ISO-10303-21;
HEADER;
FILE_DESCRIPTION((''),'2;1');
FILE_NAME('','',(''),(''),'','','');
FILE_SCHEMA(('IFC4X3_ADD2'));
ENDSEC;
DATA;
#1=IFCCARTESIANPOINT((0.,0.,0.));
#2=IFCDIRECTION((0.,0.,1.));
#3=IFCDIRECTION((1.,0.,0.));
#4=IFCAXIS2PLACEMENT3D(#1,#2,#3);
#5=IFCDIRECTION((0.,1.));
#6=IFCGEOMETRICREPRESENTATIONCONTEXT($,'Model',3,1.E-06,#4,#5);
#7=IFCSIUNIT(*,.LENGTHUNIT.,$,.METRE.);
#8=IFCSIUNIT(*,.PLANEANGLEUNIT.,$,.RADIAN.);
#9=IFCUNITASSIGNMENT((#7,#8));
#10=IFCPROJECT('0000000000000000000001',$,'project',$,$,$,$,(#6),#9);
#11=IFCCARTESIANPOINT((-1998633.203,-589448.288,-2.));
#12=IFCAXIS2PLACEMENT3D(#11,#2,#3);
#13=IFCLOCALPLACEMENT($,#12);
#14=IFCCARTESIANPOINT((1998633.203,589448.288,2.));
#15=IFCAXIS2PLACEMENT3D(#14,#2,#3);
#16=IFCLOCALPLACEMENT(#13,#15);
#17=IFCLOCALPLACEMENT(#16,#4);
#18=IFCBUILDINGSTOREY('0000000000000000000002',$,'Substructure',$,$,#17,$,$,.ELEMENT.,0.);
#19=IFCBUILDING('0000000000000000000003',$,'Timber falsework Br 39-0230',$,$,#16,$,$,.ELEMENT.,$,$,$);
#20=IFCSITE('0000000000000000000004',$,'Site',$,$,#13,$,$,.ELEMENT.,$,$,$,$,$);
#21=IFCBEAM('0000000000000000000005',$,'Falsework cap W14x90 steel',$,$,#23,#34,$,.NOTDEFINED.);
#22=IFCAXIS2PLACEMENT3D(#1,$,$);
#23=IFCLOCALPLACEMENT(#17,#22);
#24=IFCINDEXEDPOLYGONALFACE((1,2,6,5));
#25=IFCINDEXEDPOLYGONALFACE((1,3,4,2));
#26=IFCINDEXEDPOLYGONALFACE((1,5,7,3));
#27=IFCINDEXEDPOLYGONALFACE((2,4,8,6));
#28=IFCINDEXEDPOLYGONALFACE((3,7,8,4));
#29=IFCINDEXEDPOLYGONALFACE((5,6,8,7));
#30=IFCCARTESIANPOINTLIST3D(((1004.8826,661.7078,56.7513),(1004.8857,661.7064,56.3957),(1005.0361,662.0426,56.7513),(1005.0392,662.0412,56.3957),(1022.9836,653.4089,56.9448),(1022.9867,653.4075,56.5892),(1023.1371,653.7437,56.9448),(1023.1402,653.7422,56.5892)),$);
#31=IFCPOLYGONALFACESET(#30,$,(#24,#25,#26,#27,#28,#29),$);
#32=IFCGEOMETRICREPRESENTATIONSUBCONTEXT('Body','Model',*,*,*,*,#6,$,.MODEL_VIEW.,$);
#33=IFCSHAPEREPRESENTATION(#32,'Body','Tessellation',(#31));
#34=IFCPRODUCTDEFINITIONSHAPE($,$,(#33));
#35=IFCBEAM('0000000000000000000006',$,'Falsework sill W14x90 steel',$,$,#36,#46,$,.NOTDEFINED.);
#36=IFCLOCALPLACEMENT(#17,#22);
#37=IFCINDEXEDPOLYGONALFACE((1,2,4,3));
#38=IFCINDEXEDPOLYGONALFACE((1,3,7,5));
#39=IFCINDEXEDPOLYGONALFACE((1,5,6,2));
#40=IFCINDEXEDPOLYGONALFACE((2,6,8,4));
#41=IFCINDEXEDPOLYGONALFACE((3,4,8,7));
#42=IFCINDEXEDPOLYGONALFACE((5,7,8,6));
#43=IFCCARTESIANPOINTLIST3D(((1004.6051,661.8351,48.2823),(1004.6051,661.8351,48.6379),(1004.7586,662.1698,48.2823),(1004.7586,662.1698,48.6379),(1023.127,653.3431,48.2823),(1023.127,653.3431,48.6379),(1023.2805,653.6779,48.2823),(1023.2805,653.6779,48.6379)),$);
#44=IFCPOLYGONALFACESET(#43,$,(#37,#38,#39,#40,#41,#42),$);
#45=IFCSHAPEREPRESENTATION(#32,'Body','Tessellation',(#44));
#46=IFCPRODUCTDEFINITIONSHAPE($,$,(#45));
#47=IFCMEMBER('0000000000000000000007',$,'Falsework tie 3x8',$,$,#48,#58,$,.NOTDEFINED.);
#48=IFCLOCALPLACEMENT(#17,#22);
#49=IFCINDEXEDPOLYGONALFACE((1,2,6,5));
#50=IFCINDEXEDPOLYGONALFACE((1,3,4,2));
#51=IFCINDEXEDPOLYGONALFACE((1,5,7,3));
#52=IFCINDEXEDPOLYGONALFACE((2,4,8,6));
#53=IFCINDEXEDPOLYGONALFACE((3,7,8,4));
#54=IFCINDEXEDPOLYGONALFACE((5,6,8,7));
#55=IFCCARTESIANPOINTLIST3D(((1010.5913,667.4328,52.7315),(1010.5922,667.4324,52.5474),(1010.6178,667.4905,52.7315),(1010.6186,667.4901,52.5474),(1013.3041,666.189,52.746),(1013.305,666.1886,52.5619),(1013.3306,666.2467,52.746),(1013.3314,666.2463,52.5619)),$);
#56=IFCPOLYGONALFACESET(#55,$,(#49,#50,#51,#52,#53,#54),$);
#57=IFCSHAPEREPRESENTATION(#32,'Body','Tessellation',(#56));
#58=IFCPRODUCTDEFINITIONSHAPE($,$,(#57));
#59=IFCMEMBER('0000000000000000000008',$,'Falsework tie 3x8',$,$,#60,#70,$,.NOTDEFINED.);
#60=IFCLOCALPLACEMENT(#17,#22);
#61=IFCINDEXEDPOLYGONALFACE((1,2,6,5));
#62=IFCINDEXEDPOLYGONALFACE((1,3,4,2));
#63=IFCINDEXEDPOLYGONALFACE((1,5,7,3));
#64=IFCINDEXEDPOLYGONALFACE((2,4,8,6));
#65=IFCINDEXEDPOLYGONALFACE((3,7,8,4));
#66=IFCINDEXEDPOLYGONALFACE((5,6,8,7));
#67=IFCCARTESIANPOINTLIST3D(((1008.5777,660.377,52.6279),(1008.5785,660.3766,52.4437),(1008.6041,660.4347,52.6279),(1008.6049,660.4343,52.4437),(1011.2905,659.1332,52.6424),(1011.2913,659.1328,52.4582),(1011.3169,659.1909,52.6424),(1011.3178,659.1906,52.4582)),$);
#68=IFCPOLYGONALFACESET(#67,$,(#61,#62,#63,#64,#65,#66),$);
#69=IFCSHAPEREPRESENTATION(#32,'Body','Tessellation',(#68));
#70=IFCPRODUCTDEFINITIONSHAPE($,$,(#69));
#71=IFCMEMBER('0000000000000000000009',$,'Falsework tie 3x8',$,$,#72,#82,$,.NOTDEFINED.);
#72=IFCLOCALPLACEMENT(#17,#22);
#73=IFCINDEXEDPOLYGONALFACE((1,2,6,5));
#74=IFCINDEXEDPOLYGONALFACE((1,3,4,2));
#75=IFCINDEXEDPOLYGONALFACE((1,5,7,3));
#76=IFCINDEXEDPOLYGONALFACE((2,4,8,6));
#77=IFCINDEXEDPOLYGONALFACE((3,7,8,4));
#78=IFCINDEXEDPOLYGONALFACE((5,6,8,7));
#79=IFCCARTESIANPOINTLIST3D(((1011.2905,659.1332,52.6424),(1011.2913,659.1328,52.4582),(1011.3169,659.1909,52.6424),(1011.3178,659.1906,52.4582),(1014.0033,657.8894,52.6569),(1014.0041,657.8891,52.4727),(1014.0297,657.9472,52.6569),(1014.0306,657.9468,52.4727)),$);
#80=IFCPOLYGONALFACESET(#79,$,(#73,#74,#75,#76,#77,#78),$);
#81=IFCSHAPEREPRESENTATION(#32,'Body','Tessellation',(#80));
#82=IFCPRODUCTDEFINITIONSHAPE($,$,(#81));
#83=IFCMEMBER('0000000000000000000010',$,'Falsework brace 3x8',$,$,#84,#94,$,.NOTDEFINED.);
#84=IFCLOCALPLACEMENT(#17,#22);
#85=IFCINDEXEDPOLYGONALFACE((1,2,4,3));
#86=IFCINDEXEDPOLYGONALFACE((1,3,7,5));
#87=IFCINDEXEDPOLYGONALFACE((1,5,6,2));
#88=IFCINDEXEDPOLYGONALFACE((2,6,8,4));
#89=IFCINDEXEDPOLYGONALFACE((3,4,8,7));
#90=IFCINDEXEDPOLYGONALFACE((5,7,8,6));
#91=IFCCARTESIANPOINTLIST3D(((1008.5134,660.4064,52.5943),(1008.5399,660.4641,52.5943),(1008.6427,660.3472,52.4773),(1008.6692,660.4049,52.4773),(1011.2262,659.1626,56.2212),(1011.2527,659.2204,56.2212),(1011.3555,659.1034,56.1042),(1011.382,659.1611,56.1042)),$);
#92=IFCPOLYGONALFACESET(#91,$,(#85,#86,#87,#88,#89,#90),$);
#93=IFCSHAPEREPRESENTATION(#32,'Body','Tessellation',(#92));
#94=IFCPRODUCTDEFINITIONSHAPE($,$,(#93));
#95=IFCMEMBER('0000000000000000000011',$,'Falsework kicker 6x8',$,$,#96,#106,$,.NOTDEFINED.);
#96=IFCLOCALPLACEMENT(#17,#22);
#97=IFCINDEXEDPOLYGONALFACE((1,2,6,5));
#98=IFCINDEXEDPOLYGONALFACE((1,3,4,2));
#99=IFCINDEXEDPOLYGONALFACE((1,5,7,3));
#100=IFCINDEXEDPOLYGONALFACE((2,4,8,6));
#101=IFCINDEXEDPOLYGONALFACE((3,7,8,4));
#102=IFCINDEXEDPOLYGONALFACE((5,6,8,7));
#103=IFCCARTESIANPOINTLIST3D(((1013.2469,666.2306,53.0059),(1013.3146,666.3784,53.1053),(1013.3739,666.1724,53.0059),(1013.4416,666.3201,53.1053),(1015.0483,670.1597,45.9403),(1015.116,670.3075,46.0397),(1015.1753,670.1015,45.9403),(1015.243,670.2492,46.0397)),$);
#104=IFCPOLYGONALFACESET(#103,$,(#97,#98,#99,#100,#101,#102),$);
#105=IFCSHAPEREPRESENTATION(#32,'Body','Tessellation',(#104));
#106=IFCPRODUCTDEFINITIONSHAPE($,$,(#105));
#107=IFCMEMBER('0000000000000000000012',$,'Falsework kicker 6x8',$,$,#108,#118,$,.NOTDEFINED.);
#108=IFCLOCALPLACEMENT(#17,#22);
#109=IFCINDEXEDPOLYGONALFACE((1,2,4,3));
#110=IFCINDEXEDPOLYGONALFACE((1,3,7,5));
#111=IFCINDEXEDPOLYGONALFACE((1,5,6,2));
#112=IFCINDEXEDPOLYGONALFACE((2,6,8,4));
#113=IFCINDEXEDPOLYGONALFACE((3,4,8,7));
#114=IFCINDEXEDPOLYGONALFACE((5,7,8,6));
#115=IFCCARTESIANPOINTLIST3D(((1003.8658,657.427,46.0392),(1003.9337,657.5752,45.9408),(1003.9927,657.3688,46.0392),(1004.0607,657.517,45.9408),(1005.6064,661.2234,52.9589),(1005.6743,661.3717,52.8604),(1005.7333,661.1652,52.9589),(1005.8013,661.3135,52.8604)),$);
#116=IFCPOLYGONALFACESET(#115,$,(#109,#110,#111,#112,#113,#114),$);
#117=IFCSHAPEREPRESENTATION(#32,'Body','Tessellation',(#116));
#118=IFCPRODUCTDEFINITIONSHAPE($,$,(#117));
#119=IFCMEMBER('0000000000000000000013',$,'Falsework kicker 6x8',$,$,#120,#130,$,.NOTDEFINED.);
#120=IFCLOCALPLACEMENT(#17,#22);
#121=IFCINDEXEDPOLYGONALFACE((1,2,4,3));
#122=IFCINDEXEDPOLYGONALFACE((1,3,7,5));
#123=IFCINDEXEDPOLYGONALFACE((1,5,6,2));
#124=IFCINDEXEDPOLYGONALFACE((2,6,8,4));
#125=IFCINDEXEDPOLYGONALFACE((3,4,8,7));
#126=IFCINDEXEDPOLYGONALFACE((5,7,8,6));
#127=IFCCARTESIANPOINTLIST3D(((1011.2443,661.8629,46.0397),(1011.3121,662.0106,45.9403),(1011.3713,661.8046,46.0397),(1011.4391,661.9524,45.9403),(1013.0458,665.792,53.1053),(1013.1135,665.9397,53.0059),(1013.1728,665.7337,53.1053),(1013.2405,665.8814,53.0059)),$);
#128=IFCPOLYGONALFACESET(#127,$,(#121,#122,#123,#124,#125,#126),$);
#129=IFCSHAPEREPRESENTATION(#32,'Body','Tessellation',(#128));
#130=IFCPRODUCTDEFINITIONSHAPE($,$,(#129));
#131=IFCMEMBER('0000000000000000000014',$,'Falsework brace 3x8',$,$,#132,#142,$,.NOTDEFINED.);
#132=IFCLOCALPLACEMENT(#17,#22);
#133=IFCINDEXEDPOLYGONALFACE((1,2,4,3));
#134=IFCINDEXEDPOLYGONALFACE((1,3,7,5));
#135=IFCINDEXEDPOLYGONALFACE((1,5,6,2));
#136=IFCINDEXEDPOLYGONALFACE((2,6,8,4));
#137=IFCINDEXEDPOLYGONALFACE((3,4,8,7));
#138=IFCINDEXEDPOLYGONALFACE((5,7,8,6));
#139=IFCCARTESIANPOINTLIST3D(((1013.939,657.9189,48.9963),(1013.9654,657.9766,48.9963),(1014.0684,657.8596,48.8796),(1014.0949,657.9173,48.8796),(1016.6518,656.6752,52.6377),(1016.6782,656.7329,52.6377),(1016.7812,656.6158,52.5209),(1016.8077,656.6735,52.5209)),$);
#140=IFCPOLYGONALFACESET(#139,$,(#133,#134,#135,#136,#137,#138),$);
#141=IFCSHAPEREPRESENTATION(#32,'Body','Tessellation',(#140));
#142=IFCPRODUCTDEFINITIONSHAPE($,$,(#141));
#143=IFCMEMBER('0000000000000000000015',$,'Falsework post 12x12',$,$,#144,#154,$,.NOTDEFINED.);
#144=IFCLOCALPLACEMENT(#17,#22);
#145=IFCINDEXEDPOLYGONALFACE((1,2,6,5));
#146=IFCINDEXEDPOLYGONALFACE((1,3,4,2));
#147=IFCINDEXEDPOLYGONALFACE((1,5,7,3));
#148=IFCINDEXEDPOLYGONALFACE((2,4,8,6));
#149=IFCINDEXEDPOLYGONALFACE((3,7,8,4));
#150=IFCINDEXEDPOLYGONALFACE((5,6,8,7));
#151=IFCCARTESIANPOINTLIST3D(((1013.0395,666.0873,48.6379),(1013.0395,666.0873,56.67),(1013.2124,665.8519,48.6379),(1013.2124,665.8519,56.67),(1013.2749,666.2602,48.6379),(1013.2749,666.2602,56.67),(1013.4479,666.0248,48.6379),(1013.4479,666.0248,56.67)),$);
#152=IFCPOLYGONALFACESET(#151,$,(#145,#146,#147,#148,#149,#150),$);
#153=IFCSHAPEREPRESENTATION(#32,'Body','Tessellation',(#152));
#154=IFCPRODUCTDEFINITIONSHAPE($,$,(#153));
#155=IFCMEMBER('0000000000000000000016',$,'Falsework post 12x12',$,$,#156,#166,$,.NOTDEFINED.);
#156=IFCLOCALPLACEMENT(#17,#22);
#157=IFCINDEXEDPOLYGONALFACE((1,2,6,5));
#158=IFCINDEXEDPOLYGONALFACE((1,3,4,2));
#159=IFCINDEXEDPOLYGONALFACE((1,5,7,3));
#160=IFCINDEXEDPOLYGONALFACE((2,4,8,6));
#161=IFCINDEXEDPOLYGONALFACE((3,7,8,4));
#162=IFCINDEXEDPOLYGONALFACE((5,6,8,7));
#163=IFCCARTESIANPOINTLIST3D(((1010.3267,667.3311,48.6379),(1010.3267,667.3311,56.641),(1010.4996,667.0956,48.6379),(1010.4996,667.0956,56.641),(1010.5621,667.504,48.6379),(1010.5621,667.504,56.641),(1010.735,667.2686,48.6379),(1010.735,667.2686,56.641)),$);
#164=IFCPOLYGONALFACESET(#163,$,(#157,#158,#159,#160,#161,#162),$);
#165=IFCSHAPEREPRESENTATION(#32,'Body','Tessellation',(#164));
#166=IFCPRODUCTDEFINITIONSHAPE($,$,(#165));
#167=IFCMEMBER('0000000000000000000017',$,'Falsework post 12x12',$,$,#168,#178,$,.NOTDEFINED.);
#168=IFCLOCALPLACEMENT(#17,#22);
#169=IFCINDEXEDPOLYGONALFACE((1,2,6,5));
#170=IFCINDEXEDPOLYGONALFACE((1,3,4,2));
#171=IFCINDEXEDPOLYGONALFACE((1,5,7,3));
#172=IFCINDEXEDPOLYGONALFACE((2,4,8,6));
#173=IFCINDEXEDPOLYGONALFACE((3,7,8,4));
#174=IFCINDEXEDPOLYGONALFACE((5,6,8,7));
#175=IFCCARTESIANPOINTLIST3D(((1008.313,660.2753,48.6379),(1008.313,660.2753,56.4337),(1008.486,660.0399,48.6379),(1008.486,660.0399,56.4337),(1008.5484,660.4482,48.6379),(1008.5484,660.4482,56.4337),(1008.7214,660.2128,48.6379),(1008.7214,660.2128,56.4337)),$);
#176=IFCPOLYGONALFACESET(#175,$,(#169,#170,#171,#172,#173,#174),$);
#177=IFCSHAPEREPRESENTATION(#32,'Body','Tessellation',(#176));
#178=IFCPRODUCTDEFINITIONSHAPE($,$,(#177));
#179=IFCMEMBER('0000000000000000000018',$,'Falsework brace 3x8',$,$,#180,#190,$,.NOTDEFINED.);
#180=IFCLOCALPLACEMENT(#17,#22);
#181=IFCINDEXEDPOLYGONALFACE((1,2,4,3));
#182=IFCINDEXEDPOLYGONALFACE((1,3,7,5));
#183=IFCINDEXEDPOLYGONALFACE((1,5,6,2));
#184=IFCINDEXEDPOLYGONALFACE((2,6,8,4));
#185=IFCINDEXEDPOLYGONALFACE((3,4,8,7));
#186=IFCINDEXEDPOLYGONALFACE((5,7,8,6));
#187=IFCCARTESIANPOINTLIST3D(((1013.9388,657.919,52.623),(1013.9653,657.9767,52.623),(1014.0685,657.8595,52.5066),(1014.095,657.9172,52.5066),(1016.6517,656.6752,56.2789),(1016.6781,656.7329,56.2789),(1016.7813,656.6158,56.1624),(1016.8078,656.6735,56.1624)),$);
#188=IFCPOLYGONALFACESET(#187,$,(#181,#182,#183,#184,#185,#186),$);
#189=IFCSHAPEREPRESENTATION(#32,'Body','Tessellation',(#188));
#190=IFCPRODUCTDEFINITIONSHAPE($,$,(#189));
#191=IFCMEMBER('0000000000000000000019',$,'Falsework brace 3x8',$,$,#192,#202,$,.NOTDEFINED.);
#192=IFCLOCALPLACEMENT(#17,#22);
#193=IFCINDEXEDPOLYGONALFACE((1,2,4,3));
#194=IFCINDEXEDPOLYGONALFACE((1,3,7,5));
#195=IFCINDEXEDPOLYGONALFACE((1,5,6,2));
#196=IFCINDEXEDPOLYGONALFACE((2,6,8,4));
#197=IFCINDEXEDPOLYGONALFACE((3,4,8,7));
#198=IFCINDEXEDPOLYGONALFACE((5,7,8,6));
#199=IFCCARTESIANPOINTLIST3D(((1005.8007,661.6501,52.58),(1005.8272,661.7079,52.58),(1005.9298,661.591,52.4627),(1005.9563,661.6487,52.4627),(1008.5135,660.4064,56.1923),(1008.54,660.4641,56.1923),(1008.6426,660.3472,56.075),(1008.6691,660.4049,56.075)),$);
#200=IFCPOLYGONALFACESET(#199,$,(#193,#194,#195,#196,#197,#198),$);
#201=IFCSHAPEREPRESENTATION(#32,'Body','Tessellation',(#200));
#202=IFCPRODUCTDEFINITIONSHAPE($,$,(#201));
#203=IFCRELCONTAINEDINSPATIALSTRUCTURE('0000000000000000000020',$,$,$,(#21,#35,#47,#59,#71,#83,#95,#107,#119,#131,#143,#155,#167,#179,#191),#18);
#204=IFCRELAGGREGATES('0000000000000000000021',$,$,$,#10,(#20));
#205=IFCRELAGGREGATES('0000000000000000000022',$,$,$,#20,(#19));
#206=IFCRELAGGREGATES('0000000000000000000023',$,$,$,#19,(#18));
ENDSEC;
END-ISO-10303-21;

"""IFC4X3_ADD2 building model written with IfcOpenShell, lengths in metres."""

from ifc_helpers import new_model, si_unit, direction, frame, frame_2d, origin, origin_with_axes, origin_2d, place, context, subcontext, project, spatial, rectangle, extrude, element, save


model = new_model("IFC4X3_ADD2")

# Units and contexts
model_context = context("Model", 3, precision=1e-06, world=origin_with_axes(), true_north=direction((0.0, 1.0)))
body_context = subcontext(model_context, "Body", "Model", "MODEL_VIEW")
ifc_project = project(units=[si_unit("LENGTHUNIT", "METRE"), si_unit("PLANEANGLEUNIT", "RADIAN")], contexts=[model_context])

# Site, building, storey
site_placement = place(None, frame((-1998633.203, -589448.288, -2.0), z_axis=(0.0, 0.0, 1.0), x_axis=(1.0, 0.0, 0.0)))
site = spatial("IfcSite", under=ifc_project, at=site_placement, Name="Site", CompositionType="ELEMENT")
building_placement = place(site_placement, frame((1998633.203, 589448.288, 2.0), z_axis=(0.0, 0.0, 1.0), x_axis=(1.0, 0.0, 0.0)))
building = spatial("IfcBuilding", under=site, at=building_placement, Name="Timber falsework Br 39-0230", CompositionType="ELEMENT")
storey_placement = place(building_placement, origin_with_axes())
storey = spatial("IfcBuildingStorey", under=building, at=storey_placement, Name="Substructure", CompositionType="ELEMENT", Elevation=0.0)

# Beams
beam_1_placement = place(storey_placement, frame((1004.9625, 661.8738, 56.3957), z_axis=(0.908971, -0.416746, 0.009717), x_axis=(0.416765, 0.909014, 0.0)))
element("IfcBeam", 1, at=beam_1_placement, inside=storey, Name="Falsework cap W14x90 steel", PredefinedType="NOTDEFINED", context=body_context, shape_type="SweptSolid", body=[
    extrude(rectangle(XDim=0.3683, YDim=0.3556, at=frame_2d((0.0, 0.1778))), origin(), (0.0, 0.0, 1.0), 19.9137),
])
beam_2_placement = place(storey_placement, frame((1004.6819, 662.0025, 48.2823), z_axis=(0.909014, -0.416765, 0.0), x_axis=(0.416765, 0.909014, 0.0)))
element("IfcBeam", 2, at=beam_2_placement, inside=storey, Name="Falsework sill W14x90 steel", PredefinedType="NOTDEFINED", context=body_context, shape_type="SweptSolid", body=[
    extrude(rectangle(XDim=0.3683, YDim=0.3556, at=frame_2d((0.0, 0.1778))), origin(), (0.0, 0.0, 1.0), 20.3758),
])

# Members
for number, where, z_axis, x_axis, name in (
    (3, (1010.605, 667.4614, 52.6395), (0.909003, -0.41676, 0.004859), (0.416765, 0.909014, 0.0), "Falsework tie 3x8"),
    (4, (1008.5913, 660.4056, 52.5358), (0.909003, -0.41676, 0.004859), (0.416765, 0.909014, 0.0), "Falsework tie 3x8"),
    (5, (1011.3041, 659.1619, 52.5503), (0.909003, -0.41676, 0.004859), (0.416765, 0.909014, 0.0), "Falsework tie 3x8"),
):
    element("IfcMember", number, at=place(storey_placement, frame(where, z_axis=z_axis, x_axis=x_axis)), inside=storey, Name=name, PredefinedType="NOTDEFINED", context=body_context, shape_type="SweptSolid", body=[
        extrude(rectangle(XDim=0.0635, YDim=0.1841, at=origin_2d()), origin(), (0.0, 0.0, 1.0), 2.9844),
    ])
member_1_placement = place(storey_placement, frame((1008.5913, 660.4056, 52.5358), z_axis=(0.57758, -0.264809, 0.77219), x_axis=(0.416765, 0.909014, 0.0)))
element("IfcMember", 6, at=member_1_placement, inside=storey, Name="Falsework brace 3x8", PredefinedType="NOTDEFINED", context=body_context, shape_type="SweptSolid", body=[
    extrude(rectangle(XDim=0.0635, YDim=0.1841, at=origin_2d()), origin(), (0.0, 0.0, 1.0), 4.6969),
])
member_2_placement = place(storey_placement, frame((1013.3443, 666.2754, 53.0556), z_axis=(0.217488, 0.474367, -0.853039), x_axis=(-0.909014, 0.416765, 0.0)))
element("IfcMember", 7, at=member_2_placement, inside=storey, Name="Falsework kicker 6x8", PredefinedType="NOTDEFINED", context=body_context, shape_type="SweptSolid", body=[
    extrude(rectangle(XDim=0.1397, YDim=0.1905, at=origin_2d()), origin(), (0.0, 0.0, 1.0), 8.2828),
])
member_3_placement = place(storey_placement, frame((1005.7038, 661.2684, 52.9096), z_axis=(-0.215358, -0.469722, -0.856144), x_axis=(0.909014, -0.416765, 0.0)))
element("IfcMember", 8, at=member_3_placement, inside=storey, Name="Falsework kicker 6x8", PredefinedType="NOTDEFINED", context=body_context, shape_type="SweptSolid", body=[
    extrude(rectangle(XDim=0.1397, YDim=0.1905, at=origin_2d()), origin(), (0.0, 0.0, 1.0), 8.0823),
])
member_4_placement = place(storey_placement, frame((1013.1431, 665.8367, 53.0556), z_axis=(-0.217488, -0.474367, -0.853039), x_axis=(0.909014, -0.416765, 0.0)))
element("IfcMember", 9, at=member_4_placement, inside=storey, Name="Falsework kicker 6x8", PredefinedType="NOTDEFINED", context=body_context, shape_type="SweptSolid", body=[
    extrude(rectangle(XDim=0.1397, YDim=0.1905, at=origin_2d()), origin(), (0.0, 0.0, 1.0), 8.2828),
])
member_5_placement = place(storey_placement, frame((1014.0169, 657.9181, 48.9379), z_axis=(0.576205, -0.264179, 0.773432), x_axis=(0.416765, 0.909014, 0.0)))
element("IfcMember", 10, at=member_5_placement, inside=storey, Name="Falsework brace 3x8", PredefinedType="NOTDEFINED", context=body_context, shape_type="SweptSolid", body=[
    extrude(rectangle(XDim=0.0635, YDim=0.1841, at=origin_2d()), origin(), (0.0, 0.0, 1.0), 4.7081),
])
member_6_placement = place(storey_placement, frame((1013.2437, 666.056, 48.6379), z_axis=(0.0, 0.0, 1.0), x_axis=(-0.805928, -0.592013, 0.0)))
element("IfcMember", 11, at=member_6_placement, inside=storey, Name="Falsework post 12x12", PredefinedType="NOTDEFINED", context=body_context, shape_type="SweptSolid", body=[
    extrude(rectangle(XDim=0.2921, YDim=0.2921, at=origin_2d()), origin(), (0.0, 0.0, 1.0), 8.032),
])
member_7_placement = place(storey_placement, frame((1010.5309, 667.2998, 48.6379), z_axis=(0.0, 0.0, 1.0), x_axis=(-0.805928, -0.592013, 0.0)))
element("IfcMember", 12, at=member_7_placement, inside=storey, Name="Falsework post 12x12", PredefinedType="NOTDEFINED", context=body_context, shape_type="SweptSolid", body=[
    extrude(rectangle(XDim=0.2921, YDim=0.2921, at=origin_2d()), origin(), (0.0, 0.0, 1.0), 8.003),
])
member_8_placement = place(storey_placement, frame((1008.5172, 660.244, 48.6379), z_axis=(0.0, 0.0, 1.0), x_axis=(-0.805928, -0.592013, 0.0)))
element("IfcMember", 13, at=member_8_placement, inside=storey, Name="Falsework post 12x12", PredefinedType="NOTDEFINED", context=body_context, shape_type="SweptSolid", body=[
    extrude(rectangle(XDim=0.2921, YDim=0.2921, at=origin_2d()), origin(), (0.0, 0.0, 1.0), 7.7957),
])
member_9_placement = place(storey_placement, frame((1014.0169, 657.9181, 52.5648), z_axis=(0.574834, -0.26355, 0.774665), x_axis=(0.416765, 0.909014, 0.0)))
element("IfcMember", 14, at=member_9_placement, inside=storey, Name="Falsework brace 3x8", PredefinedType="NOTDEFINED", context=body_context, shape_type="SweptSolid", body=[
    extrude(rectangle(XDim=0.0635, YDim=0.1841, at=origin_2d()), origin(), (0.0, 0.0, 1.0), 4.7193),
])
member_10_placement = place(storey_placement, frame((1005.8785, 661.6494, 52.5213), z_axis=(0.578959, -0.265441, 0.77094), x_axis=(0.416765, 0.909014, 0.0)))
element("IfcMember", 15, at=member_10_placement, inside=storey, Name="Falsework brace 3x8", PredefinedType="NOTDEFINED", context=body_context, shape_type="SweptSolid", body=[
    extrude(rectangle(XDim=0.0635, YDim=0.1841, at=origin_2d()), origin(), (0.0, 0.0, 1.0), 4.6857),
])

save(model, "model.ifc")
